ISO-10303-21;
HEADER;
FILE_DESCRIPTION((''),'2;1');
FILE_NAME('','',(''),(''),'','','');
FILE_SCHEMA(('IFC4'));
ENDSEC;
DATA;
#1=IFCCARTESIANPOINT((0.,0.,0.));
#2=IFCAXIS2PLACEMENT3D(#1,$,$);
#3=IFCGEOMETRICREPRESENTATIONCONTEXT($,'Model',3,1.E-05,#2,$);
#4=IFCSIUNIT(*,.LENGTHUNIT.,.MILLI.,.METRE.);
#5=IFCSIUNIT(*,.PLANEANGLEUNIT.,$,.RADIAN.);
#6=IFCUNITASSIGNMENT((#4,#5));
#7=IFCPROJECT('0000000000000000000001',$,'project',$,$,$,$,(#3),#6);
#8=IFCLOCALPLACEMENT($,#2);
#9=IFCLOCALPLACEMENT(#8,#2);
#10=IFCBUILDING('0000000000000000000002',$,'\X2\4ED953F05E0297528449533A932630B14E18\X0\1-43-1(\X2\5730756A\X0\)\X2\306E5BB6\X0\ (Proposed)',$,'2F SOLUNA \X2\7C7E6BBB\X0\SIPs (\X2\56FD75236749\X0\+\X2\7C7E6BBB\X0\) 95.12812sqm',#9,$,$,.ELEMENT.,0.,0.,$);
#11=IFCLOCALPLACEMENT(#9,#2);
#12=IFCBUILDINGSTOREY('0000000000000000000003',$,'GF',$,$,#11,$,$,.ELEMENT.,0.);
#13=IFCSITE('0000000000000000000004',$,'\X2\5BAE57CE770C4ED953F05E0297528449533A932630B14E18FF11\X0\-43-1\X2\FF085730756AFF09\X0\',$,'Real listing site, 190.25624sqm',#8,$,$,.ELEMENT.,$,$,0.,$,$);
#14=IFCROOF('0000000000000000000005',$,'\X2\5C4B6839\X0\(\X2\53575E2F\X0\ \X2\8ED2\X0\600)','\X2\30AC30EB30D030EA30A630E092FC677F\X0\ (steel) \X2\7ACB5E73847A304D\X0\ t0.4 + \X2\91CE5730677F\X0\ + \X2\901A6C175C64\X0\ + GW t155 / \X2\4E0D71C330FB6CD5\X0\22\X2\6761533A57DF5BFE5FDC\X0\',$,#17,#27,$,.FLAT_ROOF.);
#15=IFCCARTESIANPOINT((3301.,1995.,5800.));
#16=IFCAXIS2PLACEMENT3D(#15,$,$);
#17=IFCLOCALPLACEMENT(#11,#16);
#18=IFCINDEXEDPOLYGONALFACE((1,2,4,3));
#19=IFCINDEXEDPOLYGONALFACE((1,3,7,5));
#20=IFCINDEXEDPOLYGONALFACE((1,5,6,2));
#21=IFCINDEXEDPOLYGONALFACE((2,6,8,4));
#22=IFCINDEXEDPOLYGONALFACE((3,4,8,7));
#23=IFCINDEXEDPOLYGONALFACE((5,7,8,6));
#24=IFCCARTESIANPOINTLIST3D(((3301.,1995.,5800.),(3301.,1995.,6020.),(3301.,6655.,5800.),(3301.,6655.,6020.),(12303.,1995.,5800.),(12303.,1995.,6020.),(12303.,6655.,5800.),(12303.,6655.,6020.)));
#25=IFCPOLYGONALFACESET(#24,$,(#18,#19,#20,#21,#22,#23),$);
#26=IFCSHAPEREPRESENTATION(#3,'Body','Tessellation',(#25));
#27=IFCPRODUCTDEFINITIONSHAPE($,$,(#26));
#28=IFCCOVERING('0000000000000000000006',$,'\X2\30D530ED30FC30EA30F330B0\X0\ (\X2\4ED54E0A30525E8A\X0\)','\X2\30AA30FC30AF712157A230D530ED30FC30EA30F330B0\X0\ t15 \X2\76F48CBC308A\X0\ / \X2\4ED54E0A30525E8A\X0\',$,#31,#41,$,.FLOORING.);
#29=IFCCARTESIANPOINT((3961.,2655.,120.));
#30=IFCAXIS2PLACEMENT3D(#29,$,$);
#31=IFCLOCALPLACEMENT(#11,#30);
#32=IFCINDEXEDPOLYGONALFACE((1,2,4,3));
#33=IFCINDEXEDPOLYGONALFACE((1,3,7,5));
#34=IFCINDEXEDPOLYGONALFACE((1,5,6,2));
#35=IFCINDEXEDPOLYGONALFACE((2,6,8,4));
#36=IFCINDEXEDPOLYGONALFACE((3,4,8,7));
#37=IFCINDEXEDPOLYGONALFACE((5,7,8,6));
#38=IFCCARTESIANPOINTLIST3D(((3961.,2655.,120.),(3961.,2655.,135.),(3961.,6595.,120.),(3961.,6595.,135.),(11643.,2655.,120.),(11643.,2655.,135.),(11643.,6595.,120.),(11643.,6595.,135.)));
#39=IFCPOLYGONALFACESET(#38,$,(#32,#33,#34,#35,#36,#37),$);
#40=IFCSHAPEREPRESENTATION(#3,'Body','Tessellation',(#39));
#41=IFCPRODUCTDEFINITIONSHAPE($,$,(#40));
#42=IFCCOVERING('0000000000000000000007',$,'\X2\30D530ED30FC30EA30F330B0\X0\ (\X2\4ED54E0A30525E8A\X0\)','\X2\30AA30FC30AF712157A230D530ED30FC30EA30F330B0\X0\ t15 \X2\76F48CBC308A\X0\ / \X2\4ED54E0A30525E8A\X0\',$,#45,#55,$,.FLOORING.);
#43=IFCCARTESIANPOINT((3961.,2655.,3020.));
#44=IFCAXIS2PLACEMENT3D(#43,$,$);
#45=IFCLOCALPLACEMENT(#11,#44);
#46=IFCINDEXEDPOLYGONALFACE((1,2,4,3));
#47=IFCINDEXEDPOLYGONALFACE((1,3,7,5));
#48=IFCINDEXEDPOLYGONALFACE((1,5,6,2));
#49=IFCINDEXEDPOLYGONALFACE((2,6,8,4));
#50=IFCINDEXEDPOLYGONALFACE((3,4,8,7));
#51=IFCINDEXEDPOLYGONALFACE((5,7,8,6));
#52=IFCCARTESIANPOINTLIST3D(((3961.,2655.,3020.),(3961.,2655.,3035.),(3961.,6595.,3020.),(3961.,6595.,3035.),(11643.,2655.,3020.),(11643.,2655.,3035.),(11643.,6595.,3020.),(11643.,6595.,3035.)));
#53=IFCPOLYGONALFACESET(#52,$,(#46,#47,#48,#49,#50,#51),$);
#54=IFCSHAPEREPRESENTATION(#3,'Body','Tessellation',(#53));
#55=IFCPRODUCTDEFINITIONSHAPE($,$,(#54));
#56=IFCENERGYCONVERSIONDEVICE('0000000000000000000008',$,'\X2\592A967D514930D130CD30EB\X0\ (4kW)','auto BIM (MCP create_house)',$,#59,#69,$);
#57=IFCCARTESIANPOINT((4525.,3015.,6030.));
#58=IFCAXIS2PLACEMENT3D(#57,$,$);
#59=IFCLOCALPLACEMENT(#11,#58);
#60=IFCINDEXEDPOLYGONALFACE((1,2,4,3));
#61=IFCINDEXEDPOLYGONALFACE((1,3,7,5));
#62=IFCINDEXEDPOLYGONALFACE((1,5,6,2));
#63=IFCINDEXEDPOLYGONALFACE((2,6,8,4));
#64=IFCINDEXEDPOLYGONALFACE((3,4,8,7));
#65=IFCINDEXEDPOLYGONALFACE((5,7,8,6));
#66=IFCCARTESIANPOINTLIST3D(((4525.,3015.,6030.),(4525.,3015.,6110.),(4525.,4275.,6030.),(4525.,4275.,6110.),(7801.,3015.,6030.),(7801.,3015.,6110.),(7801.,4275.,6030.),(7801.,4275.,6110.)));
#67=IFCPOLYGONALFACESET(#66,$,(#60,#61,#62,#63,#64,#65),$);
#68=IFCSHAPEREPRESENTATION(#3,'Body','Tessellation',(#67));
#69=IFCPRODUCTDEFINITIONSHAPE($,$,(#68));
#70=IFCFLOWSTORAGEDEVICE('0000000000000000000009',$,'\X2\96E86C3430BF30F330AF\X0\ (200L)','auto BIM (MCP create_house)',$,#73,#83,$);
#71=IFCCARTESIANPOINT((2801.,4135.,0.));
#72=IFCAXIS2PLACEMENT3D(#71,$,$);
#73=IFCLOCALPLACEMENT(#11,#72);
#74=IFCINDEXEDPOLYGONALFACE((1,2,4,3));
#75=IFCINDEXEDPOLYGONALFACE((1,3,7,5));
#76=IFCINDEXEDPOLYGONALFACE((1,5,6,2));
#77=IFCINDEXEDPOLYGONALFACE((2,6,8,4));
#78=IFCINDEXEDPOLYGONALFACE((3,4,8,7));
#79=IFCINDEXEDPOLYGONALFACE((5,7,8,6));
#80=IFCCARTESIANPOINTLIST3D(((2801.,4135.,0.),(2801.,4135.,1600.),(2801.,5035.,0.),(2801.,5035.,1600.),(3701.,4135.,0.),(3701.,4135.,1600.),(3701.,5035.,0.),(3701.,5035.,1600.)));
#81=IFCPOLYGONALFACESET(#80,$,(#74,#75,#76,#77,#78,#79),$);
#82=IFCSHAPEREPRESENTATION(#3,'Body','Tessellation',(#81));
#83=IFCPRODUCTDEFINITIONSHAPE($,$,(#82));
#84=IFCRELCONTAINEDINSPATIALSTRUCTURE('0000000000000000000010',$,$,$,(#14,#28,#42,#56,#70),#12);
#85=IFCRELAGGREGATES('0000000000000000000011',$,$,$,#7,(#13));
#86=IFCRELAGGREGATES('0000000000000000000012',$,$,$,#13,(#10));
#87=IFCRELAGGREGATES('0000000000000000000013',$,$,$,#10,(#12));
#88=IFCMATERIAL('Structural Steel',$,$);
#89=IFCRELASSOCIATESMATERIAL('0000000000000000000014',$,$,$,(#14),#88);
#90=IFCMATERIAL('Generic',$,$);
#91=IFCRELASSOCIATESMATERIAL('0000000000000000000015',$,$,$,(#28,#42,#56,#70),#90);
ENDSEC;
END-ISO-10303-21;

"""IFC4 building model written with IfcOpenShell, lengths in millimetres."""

from ifc_helpers import new_model, si_unit, frame, frame_2d, origin, place, context, project, spatial, rectangle, extrude, material, element, save


model = new_model("IFC4")

# Units and contexts
model_context = context("Model", 3, precision=1e-05, world=origin())
ifc_project = project(units=[si_unit("LENGTHUNIT", "METRE", prefix="MILLI"), si_unit("PLANEANGLEUNIT", "RADIAN")], contexts=[model_context])

# Site, building, storey
site_placement = place(None, origin())
site = spatial("IfcSite", under=ifc_project, at=site_placement, Name="宮城県仙台市青葉区錦ケ丘１-43-1（地番）", ObjectType="Real listing site, 190.25624sqm", CompositionType="ELEMENT", RefElevation=0.0)
building_placement = place(site_placement, origin())
building = spatial("IfcBuilding", under=site, at=building_placement, Name="仙台市青葉区錦ケ丘1-43-1(地番)の家 (Proposed)", ObjectType="2F SOLUNA 籾殻SIPs (国産杉+籾殻) 95.12812sqm", CompositionType="ELEMENT", ElevationOfRefHeight=0.0, ElevationOfTerrain=0.0)
storey_placement = place(building_placement, origin())
storey = spatial("IfcBuildingStorey", under=building, at=storey_placement, Name="GF", CompositionType="ELEMENT", Elevation=0.0)

# Roof
ifc_material_1 = material(Name="Structural Steel")
for number, where, name in (
    (1, (3301.0, 1995.0, 5800.0), "屋根(南帯 軒600)"),
):
    element("IfcRoof", number, at=place(storey_placement, frame(where)), inside=storey, material=ifc_material_1, Name=name, Description="ガルバリウム鋼板 (steel) 立平葺き t0.4 + 野地板 + 通気層 + GW t155 / 不燃・法22条区域対応", PredefinedType="FLAT_ROOF", context=model_context, shape_type="SweptSolid", body=[
        extrude(rectangle(XDim=9002.0, YDim=4660.0, at=frame_2d((4501.0, 2330.0))), frame((3301.0, 1995.0, 5800.0)), (0.0, 0.0, 1.0), 220.0),
    ])

# Coverings
ifc_material_2 = material(Name="Generic")
covering_1_placement = place(storey_placement, frame((3961.0, 2655.0, 120.0)))
element("IfcCovering", 2, at=covering_1_placement, inside=storey, material=ifc_material_2, Name="フローリング (仕上げ床)", Description="オーク無垢フローリング t15 直貼り / 仕上げ床", PredefinedType="FLOORING", context=model_context, shape_type="SweptSolid", body=[
    extrude(rectangle(XDim=7682.0, YDim=3940.0, at=frame_2d((3841.0, 1970.0))), frame((3961.0, 2655.0, 120.0)), (0.0, 0.0, 1.0), 15.0),
])
covering_2_placement = place(storey_placement, frame((3961.0, 2655.0, 3020.0)))
element("IfcCovering", 3, at=covering_2_placement, inside=storey, material=ifc_material_2, Name="フローリング (仕上げ床)", Description="オーク無垢フローリング t15 直貼り / 仕上げ床", PredefinedType="FLOORING", context=model_context, shape_type="SweptSolid", body=[
    extrude(rectangle(XDim=7682.0, YDim=3940.0, at=frame_2d((3841.0, 1970.0))), frame((3961.0, 2655.0, 3020.0)), (0.0, 0.0, 1.0), 15.0),
])

# Energy conversion device
energy_conversion_device_placement = place(storey_placement, frame((4525.0, 3015.0, 6030.0)))
element("IfcEnergyConversionDevice", 4, at=energy_conversion_device_placement, inside=storey, material=ifc_material_2, Name="太陽光パネル (4kW)", Description="auto BIM (MCP create_house)", context=model_context, shape_type="SweptSolid", body=[
    extrude(rectangle(XDim=3276.0, YDim=1260.0, at=frame_2d((1638.0, 630.0))), frame((4525.0, 3015.0, 6030.0)), (0.0, 0.0, 1.0), 80.0),
])

# Flow storage device
flow_storage_device_placement = place(storey_placement, frame((2801.0, 4135.0, 0.0)))
element("IfcFlowStorageDevice", 5, at=flow_storage_device_placement, inside=storey, material=ifc_material_2, Name="雨水タンク (200L)", Description="auto BIM (MCP create_house)", context=model_context, shape_type="SweptSolid", body=[
    extrude(rectangle(XDim=900.0, YDim=900.0, at=frame_2d((450.0, 450.0))), frame((2801.0, 4135.0, 0.0)), (0.0, 0.0, 1.0), 1600.0),
])

save(model, "model.ifc")
